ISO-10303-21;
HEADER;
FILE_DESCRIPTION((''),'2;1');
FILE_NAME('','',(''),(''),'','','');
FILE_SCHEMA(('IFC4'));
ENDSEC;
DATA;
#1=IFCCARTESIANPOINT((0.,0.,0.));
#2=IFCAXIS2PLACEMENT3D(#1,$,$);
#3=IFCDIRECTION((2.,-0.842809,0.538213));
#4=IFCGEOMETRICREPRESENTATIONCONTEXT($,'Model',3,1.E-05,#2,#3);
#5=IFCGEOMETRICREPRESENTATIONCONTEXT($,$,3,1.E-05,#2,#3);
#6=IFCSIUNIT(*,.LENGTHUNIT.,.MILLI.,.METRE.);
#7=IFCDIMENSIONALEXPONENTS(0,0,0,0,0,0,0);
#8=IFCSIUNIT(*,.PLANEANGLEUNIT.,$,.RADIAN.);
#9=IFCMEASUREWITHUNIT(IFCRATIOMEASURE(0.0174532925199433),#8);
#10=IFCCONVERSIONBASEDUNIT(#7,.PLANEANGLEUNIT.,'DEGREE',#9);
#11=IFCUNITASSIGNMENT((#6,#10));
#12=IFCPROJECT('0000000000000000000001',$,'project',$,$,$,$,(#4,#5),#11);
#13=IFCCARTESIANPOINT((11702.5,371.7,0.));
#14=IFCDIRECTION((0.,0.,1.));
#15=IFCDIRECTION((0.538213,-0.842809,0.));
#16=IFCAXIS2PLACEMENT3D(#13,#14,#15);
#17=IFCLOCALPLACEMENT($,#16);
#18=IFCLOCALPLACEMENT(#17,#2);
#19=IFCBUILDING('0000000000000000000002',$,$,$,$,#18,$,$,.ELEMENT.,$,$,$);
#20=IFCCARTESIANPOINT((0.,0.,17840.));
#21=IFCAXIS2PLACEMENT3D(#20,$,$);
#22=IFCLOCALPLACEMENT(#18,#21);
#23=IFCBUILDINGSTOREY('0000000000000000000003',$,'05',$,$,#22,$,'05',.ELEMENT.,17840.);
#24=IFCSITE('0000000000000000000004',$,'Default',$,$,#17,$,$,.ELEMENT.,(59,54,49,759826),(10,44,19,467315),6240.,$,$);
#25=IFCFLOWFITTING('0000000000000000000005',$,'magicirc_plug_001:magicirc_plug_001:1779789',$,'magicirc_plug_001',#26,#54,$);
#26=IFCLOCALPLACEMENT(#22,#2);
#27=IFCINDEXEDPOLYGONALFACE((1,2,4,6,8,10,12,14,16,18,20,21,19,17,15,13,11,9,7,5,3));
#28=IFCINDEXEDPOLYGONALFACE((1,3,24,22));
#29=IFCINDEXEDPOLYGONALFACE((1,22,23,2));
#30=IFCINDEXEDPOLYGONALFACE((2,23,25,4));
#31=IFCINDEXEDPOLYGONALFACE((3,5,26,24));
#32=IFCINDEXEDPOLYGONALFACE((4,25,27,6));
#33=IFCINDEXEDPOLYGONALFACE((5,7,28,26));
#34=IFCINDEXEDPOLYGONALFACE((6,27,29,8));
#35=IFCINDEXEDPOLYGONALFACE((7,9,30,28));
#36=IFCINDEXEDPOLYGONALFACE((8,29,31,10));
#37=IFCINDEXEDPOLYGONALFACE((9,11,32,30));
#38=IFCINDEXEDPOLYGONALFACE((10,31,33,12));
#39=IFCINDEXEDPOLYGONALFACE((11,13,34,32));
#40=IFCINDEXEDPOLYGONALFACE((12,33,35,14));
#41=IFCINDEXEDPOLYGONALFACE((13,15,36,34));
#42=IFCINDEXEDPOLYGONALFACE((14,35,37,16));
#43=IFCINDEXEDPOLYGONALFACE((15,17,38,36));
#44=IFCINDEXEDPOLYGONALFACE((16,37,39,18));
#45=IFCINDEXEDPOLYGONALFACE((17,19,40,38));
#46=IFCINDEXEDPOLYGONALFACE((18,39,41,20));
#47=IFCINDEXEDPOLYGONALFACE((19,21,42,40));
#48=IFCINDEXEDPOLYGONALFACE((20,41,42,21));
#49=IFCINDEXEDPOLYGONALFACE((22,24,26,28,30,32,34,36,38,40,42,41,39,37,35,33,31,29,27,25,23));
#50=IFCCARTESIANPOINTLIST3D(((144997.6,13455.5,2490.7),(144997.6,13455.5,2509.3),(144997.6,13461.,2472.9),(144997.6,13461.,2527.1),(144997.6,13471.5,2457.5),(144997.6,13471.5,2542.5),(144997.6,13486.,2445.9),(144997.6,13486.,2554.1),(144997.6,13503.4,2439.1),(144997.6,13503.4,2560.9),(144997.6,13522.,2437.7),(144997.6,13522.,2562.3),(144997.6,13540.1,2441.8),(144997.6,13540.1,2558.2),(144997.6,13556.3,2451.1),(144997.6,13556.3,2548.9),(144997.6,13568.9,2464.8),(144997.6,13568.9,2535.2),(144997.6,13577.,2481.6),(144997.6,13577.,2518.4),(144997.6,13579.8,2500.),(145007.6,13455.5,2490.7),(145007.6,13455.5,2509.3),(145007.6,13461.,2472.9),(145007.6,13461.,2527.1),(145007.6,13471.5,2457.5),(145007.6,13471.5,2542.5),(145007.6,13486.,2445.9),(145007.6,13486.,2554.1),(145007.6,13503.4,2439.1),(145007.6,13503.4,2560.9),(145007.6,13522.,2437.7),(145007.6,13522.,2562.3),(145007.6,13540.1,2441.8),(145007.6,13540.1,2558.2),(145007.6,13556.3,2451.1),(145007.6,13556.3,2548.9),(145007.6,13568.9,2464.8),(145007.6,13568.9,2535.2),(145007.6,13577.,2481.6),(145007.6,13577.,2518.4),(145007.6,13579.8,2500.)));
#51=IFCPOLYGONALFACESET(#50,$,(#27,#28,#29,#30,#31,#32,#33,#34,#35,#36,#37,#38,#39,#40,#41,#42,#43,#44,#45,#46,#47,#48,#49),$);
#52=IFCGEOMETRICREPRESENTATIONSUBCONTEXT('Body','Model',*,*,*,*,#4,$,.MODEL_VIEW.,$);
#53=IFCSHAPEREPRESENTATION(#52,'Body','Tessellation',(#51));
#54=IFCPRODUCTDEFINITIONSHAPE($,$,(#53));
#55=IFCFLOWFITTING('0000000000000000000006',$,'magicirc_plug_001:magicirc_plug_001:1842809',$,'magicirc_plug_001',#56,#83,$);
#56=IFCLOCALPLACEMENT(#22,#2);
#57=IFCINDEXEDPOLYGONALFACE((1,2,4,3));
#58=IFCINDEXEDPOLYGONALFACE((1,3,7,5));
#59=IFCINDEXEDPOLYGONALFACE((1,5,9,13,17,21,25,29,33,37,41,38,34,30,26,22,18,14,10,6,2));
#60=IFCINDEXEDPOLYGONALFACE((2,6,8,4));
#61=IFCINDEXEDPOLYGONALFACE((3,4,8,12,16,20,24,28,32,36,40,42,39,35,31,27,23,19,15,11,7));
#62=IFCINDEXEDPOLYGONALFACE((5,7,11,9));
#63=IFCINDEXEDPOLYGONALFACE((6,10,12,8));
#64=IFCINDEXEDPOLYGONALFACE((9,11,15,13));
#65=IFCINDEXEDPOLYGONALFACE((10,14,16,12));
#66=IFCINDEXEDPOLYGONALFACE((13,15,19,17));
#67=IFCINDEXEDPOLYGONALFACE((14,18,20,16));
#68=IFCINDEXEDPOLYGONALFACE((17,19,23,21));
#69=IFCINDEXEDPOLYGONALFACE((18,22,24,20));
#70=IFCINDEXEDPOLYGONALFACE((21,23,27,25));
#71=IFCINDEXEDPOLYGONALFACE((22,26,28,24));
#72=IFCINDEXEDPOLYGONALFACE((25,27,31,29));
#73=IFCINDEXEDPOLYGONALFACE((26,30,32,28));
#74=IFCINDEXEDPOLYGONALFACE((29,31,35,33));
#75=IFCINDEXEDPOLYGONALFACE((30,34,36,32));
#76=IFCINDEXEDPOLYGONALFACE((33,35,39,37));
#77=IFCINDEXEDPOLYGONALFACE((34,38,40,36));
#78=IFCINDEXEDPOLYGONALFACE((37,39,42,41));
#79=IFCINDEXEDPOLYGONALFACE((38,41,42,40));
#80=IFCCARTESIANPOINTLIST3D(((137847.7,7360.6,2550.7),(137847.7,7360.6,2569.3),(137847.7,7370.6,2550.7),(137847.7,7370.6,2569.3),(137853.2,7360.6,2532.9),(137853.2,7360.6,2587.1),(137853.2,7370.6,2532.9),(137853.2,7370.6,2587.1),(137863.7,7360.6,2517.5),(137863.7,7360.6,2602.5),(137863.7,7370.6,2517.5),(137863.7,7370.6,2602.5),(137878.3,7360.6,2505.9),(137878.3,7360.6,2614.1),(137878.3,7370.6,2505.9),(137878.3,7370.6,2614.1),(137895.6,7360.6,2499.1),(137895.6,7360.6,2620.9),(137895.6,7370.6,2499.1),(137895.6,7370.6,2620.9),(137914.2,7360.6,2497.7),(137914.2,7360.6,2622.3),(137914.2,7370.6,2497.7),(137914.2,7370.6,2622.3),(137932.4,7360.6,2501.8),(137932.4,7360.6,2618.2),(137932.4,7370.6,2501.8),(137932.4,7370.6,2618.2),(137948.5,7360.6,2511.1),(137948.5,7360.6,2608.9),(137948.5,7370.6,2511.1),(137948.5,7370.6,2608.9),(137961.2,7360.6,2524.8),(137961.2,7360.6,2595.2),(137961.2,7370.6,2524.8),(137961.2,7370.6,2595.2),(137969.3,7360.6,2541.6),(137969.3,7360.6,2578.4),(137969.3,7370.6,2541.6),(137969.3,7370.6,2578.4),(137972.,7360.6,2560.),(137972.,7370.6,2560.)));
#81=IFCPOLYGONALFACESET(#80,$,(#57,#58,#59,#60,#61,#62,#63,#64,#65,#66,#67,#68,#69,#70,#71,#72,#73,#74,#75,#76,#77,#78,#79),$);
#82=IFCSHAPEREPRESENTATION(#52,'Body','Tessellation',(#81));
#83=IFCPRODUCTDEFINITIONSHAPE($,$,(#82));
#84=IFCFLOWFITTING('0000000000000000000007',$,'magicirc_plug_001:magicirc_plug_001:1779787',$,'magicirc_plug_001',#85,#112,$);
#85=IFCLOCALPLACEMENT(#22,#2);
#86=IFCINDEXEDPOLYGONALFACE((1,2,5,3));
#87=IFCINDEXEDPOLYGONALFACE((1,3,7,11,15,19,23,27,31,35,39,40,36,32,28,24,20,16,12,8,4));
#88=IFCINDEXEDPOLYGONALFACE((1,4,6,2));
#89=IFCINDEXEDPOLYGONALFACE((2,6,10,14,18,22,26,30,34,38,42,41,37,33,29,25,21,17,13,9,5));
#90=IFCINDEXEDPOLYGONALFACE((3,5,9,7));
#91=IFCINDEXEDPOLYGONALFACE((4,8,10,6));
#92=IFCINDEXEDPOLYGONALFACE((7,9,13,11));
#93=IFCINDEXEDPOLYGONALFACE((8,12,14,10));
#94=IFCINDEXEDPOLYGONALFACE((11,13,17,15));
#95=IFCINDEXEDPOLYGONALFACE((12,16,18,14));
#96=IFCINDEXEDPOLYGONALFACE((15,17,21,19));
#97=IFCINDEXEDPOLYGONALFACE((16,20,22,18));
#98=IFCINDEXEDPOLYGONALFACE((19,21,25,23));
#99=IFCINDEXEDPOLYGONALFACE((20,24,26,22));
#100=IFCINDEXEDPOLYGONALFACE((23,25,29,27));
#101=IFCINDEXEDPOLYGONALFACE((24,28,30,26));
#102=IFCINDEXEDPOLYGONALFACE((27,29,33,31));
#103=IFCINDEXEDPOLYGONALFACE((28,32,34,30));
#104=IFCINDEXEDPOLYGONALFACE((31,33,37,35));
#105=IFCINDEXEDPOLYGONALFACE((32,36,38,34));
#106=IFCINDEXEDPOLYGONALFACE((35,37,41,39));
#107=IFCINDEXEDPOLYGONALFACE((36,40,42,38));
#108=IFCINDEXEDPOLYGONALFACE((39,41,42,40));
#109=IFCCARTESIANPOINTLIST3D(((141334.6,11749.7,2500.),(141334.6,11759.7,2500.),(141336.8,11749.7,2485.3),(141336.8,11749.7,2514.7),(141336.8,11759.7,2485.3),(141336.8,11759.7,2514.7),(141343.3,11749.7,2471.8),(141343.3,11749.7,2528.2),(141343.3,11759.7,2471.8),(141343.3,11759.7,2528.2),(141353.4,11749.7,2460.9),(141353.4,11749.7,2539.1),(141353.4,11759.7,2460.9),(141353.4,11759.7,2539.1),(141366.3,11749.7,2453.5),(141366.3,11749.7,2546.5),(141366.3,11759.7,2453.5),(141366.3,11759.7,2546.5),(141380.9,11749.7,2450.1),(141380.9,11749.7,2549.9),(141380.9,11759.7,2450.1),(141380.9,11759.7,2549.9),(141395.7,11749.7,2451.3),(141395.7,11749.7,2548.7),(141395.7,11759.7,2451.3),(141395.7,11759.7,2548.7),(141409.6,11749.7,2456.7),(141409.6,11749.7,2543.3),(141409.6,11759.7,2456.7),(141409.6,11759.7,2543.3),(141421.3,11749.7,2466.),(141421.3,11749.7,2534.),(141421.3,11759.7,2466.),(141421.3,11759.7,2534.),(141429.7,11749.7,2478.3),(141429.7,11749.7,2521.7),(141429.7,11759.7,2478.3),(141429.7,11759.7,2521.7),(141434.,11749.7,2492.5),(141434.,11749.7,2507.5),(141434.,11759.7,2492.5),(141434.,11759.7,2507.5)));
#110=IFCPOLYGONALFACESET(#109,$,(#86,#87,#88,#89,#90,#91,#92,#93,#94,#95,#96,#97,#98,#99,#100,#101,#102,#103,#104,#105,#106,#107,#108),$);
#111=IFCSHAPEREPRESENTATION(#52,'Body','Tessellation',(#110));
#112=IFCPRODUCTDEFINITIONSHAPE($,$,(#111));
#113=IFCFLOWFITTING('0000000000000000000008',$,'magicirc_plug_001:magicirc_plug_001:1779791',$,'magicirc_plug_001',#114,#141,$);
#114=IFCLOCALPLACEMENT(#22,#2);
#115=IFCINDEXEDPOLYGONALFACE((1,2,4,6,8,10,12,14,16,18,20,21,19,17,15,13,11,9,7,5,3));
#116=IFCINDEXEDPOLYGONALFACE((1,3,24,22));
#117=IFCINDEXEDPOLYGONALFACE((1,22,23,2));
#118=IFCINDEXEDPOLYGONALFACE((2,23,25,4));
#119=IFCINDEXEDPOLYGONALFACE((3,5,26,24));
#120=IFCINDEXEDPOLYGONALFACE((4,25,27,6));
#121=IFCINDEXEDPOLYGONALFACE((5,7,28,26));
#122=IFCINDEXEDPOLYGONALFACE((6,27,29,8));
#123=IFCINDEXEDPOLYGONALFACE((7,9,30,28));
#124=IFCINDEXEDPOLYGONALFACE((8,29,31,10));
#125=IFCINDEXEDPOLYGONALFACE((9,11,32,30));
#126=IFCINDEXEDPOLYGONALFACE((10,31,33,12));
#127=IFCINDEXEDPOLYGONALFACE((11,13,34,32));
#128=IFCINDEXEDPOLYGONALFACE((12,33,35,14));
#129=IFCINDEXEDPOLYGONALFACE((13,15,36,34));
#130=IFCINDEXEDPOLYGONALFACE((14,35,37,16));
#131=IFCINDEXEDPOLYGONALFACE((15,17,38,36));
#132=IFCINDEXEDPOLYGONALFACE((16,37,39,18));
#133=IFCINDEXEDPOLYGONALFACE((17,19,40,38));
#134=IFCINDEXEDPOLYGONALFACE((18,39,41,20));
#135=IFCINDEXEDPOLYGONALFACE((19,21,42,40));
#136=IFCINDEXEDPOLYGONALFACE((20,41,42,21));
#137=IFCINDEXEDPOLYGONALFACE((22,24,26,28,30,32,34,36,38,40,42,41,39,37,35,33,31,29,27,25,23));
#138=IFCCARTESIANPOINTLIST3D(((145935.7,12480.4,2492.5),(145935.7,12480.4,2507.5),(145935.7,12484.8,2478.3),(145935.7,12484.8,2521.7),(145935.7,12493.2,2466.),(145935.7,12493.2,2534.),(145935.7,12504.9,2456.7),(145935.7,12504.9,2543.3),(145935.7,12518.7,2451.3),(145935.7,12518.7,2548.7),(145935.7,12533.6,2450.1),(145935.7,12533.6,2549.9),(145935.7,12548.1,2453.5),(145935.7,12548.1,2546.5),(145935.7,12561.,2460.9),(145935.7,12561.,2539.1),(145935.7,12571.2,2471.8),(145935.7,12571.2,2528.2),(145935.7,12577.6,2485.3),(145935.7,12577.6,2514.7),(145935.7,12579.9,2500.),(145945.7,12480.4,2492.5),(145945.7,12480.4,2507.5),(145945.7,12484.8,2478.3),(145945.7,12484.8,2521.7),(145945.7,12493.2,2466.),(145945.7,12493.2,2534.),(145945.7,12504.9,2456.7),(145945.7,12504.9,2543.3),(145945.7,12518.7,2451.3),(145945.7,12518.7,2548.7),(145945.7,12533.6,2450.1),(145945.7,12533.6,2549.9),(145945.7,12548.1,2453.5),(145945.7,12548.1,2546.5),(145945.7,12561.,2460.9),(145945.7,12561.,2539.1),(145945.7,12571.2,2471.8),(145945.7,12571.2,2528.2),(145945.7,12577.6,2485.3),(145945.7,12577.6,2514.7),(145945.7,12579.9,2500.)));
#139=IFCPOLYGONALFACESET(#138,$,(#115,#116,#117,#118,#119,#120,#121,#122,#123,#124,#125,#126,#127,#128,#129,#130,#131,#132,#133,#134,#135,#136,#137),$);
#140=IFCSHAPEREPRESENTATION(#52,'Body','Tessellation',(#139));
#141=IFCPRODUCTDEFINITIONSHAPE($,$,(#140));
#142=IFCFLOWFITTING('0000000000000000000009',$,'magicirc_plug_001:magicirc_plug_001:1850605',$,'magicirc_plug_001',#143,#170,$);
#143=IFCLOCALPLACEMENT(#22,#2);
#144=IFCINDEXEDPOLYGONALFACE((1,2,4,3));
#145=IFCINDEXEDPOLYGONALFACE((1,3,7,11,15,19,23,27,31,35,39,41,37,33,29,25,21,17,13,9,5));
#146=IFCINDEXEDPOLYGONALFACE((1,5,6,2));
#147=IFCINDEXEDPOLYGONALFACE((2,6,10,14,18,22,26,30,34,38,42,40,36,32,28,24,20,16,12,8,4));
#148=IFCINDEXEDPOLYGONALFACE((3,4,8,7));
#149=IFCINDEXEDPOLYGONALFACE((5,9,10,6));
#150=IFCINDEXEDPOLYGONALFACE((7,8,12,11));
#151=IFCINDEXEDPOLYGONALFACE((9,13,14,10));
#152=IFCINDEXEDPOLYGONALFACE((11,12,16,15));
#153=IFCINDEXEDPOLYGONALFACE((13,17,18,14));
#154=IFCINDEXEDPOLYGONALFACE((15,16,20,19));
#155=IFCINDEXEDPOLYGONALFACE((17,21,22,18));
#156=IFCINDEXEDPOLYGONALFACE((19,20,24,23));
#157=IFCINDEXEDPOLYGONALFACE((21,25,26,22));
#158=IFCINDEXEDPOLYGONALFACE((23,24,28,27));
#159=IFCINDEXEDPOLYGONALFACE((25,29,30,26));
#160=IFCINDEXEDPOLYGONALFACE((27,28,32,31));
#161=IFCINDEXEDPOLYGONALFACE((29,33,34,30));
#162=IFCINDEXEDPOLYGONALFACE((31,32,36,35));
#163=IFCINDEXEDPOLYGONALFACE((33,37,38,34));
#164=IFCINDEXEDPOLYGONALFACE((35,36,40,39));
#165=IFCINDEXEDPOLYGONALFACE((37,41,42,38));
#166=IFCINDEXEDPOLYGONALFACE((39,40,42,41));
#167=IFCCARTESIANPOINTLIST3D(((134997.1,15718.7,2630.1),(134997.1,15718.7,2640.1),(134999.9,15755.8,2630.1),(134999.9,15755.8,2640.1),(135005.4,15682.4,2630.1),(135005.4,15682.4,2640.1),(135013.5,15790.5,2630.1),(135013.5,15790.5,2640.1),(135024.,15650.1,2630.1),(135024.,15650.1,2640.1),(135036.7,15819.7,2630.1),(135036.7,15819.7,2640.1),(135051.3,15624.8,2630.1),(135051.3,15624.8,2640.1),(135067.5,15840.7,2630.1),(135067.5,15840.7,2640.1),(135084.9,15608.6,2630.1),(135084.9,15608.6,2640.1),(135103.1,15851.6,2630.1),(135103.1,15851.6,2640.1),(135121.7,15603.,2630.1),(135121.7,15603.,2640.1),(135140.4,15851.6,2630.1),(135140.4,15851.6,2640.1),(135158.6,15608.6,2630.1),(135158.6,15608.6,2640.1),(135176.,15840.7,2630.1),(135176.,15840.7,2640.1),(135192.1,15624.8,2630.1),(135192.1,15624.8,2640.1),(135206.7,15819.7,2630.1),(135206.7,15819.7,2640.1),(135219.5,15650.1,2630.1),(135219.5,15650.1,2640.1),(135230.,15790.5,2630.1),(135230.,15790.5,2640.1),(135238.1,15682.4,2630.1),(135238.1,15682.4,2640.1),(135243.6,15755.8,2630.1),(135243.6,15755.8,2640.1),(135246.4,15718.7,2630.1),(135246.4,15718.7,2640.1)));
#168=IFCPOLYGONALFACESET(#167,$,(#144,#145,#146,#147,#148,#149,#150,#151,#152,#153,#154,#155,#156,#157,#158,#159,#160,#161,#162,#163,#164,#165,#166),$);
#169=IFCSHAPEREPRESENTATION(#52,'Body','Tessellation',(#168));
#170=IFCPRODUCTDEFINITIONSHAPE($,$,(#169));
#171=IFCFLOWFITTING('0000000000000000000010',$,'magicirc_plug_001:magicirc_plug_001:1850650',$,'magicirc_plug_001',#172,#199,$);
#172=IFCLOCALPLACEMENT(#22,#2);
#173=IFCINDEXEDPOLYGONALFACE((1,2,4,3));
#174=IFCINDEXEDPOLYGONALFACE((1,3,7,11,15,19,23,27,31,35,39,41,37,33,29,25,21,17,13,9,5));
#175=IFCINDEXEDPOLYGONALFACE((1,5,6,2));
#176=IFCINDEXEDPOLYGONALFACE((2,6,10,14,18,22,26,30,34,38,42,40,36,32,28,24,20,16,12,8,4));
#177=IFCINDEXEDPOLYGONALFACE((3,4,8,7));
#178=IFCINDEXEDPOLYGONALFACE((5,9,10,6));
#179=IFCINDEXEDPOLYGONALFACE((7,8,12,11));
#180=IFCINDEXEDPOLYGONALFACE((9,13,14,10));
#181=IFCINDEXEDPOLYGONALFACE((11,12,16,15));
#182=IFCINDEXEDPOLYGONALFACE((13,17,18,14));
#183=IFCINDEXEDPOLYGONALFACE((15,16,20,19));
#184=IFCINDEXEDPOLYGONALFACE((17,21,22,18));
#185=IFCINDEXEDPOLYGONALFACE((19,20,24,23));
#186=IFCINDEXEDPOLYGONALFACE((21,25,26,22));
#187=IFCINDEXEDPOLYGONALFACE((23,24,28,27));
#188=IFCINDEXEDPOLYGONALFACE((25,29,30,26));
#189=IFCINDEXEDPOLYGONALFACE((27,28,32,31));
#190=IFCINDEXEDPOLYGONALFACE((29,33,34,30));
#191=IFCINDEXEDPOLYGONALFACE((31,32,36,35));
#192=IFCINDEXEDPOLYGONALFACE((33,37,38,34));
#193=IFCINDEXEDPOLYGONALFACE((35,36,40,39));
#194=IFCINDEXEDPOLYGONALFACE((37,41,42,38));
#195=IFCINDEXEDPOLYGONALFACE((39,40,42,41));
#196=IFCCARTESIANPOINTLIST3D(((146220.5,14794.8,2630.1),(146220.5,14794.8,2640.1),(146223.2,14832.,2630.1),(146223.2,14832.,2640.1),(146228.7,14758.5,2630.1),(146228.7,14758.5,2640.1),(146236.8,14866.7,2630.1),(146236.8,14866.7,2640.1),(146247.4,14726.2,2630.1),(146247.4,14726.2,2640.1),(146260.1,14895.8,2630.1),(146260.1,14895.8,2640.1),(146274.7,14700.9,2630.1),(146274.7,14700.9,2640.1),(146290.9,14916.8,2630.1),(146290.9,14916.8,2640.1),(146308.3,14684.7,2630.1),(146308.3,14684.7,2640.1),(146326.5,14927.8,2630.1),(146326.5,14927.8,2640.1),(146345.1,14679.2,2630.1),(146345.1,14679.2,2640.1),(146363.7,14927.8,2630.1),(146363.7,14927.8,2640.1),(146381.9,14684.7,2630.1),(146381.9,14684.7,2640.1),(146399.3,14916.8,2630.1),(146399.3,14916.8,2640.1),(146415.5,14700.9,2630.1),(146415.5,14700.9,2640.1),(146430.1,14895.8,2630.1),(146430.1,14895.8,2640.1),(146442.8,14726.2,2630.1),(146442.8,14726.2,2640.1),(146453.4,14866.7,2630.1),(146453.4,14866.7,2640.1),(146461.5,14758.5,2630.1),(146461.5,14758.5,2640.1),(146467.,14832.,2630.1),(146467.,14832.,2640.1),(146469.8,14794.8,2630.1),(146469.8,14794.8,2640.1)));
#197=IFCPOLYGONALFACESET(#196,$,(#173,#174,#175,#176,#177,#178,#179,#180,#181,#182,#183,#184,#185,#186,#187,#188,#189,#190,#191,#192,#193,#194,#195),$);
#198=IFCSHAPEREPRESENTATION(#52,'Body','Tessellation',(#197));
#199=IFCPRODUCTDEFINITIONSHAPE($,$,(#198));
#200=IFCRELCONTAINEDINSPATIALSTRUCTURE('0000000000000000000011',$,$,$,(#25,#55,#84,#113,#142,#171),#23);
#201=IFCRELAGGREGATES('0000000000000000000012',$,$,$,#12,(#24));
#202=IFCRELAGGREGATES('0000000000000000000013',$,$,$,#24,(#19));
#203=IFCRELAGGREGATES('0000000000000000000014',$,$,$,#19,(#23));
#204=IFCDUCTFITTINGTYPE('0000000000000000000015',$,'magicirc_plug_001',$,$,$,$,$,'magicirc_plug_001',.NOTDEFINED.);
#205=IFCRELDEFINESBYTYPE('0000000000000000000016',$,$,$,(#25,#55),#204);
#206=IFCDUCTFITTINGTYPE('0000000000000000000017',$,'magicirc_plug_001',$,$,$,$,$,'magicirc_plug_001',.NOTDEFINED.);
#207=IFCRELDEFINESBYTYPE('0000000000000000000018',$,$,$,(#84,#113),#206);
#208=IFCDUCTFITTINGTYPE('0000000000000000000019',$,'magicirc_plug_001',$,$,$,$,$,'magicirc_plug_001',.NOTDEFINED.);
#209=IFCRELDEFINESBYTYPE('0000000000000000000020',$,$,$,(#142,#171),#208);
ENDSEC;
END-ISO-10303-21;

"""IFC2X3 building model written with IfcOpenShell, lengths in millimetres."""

from ifc_helpers import new_model, entity, si_unit, converted_unit, direction, frame, frame_2d, origin, place, context, subcontext, project, spatial, circle, extrude, source, transform, mapped, type_object, type_shapes, element, save


model = new_model("IFC2X3")

# Units and contexts
model_context = context("Model", 3, precision=1e-05, world=origin(), true_north=direction((2.0, -0.842809, 0.538213)))
context_of_model = context(None, 3, precision=1e-05, world=origin(), true_north=direction((2.0, -0.842809, 0.538213)))
body_context = subcontext(model_context, "Body", "Model", "MODEL_VIEW")
ifc_project = project(units=[si_unit("LENGTHUNIT", "METRE", prefix="MILLI"), converted_unit("PLANEANGLEUNIT", "DEGREE", entity("IfcRatioMeasure", 0.0174532925199433), si_unit("PLANEANGLEUNIT", "RADIAN"), dimensions=[0, 0, 0, 0, 0, 0, 0])], contexts=[model_context, context_of_model])

# Site, building, storey
site_placement = place(None, frame((11702.5, 371.7, 0.0), z_axis=(0.0, 0.0, 1.0), x_axis=(0.538213, -0.842809, 0.0)))
site = spatial("IfcSite", under=ifc_project, at=site_placement, Name="Default", CompositionType="ELEMENT", RefLatitude=(59, 54, 49, 759826), RefLongitude=(10, 44, 19, 467315), RefElevation=6240.0)
building_placement = place(site_placement, origin())
building = spatial("IfcBuilding", under=site, at=building_placement, CompositionType="ELEMENT")
storey_placement = place(building_placement, frame((0.0, 0.0, 17840.0)))
storey = spatial("IfcBuildingStorey", under=building, at=storey_placement, Name="05", LongName="05", CompositionType="ELEMENT", Elevation=17840.0)

# Flow fittings
duct_fitting_type_1 = type_object("IfcDuctFittingType", Name="magicirc_plug_001", ElementType="magicirc_plug_001", PredefinedType="NOTDEFINED")
shared_shape_1 = source(origin(), body_context, "Body", "SweptSolid", [
    extrude(circle(Radius=62.5, at=frame_2d((0.0, 0.0), x_axis=(1.0, 0.0))), frame((0.0, 0.0, 0.0), z_axis=(1.0, 0.0, 0.0), x_axis=(0.0, 1.0, 0.0)), (0.0, 0.0, 1.0), 10.0),
])
type_shapes(duct_fitting_type_1, [shared_shape_1])
flow_fitting_1_placement = place(storey_placement, frame((144997.6, 13517.3, 2500.0)))
element("IfcFlowFitting", 1, at=flow_fitting_1_placement, inside=storey, type_object=duct_fitting_type_1, Name="magicirc_plug_001:magicirc_plug_001:1779789", ObjectType="magicirc_plug_001", context=body_context, shape_type="MappedRepresentation", body=[
    mapped(shared_shape_1, transform((0.0, 0.0, 0.0), scale=1.0)),
])
flow_fitting_2_placement = place(storey_placement, frame((137909.5, 7370.6, 2560.0), z_axis=(0.0, 0.0, 1.0), x_axis=(0.0, -1.0, 0.0)))
element("IfcFlowFitting", 2, at=flow_fitting_2_placement, inside=storey, type_object=duct_fitting_type_1, Name="magicirc_plug_001:magicirc_plug_001:1842809", ObjectType="magicirc_plug_001", context=body_context, shape_type="MappedRepresentation", body=[
    mapped(shared_shape_1, transform((0.0, 0.0, 0.0), scale=1.0)),
])
duct_fitting_type_2 = type_object("IfcDuctFittingType", Name="magicirc_plug_001", ElementType="magicirc_plug_001", PredefinedType="NOTDEFINED")
shared_shape_2 = source(origin(), body_context, "Body", "SweptSolid", [
    extrude(circle(Radius=50.0, at=frame_2d((0.0, 0.0), x_axis=(1.0, 0.0))), frame((0.0, 0.0, 0.0), z_axis=(1.0, 0.0, 0.0), x_axis=(0.0, 1.0, 0.0)), (0.0, 0.0, 1.0), 10.0),
])
type_shapes(duct_fitting_type_2, [shared_shape_2])
flow_fitting_3_placement = place(storey_placement, frame((141384.6, 11749.7, 2500.0), z_axis=(0.0, 0.0, 1.0), x_axis=(0.0, 1.0, 0.0)))
element("IfcFlowFitting", 3, at=flow_fitting_3_placement, inside=storey, type_object=duct_fitting_type_2, Name="magicirc_plug_001:magicirc_plug_001:1779787", ObjectType="magicirc_plug_001", context=body_context, shape_type="MappedRepresentation", body=[
    mapped(shared_shape_2, transform((0.0, 0.0, 0.0), scale=1.0)),
])
flow_fitting_4_placement = place(storey_placement, frame((145935.7, 12529.9, 2500.0)))
element("IfcFlowFitting", 4, at=flow_fitting_4_placement, inside=storey, type_object=duct_fitting_type_2, Name="magicirc_plug_001:magicirc_plug_001:1779791", ObjectType="magicirc_plug_001", context=body_context, shape_type="MappedRepresentation", body=[
    mapped(shared_shape_2, transform((0.0, 0.0, 0.0), scale=1.0)),
])
duct_fitting_type_3 = type_object("IfcDuctFittingType", Name="magicirc_plug_001", ElementType="magicirc_plug_001", PredefinedType="NOTDEFINED")
shared_shape_3 = source(origin(), body_context, "Body", "SweptSolid", [
    extrude(circle(Radius=125.0, at=frame_2d((0.0, 0.0), x_axis=(1.0, 0.0))), frame((0.0, 0.0, 0.0), z_axis=(1.0, 0.0, 0.0), x_axis=(0.0, 1.0, 0.0)), (0.0, 0.0, 1.0), 10.0),
])
type_shapes(duct_fitting_type_3, [shared_shape_3])
for number, where, z_axis, x_axis, name in (
    (5, (135121.7, 15728.0, 2630.1), (1.0, 0.0, 0.0), (0.0, 0.0, 1.0), "magicirc_plug_001:magicirc_plug_001:1850605"),
    (6, (146345.1, 14804.2, 2630.1), (1.0, 0.0, 0.0), (0.0, 0.0, 1.0), "magicirc_plug_001:magicirc_plug_001:1850650"),
):
    element("IfcFlowFitting", number, at=place(storey_placement, frame(where, z_axis=z_axis, x_axis=x_axis)), inside=storey, type_object=duct_fitting_type_3, Name=name, ObjectType="magicirc_plug_001", context=body_context, shape_type="MappedRepresentation", body=[
        mapped(shared_shape_3, transform((0.0, 0.0, 0.0), scale=1.0)),
    ])

save(model, "model.ifc")
